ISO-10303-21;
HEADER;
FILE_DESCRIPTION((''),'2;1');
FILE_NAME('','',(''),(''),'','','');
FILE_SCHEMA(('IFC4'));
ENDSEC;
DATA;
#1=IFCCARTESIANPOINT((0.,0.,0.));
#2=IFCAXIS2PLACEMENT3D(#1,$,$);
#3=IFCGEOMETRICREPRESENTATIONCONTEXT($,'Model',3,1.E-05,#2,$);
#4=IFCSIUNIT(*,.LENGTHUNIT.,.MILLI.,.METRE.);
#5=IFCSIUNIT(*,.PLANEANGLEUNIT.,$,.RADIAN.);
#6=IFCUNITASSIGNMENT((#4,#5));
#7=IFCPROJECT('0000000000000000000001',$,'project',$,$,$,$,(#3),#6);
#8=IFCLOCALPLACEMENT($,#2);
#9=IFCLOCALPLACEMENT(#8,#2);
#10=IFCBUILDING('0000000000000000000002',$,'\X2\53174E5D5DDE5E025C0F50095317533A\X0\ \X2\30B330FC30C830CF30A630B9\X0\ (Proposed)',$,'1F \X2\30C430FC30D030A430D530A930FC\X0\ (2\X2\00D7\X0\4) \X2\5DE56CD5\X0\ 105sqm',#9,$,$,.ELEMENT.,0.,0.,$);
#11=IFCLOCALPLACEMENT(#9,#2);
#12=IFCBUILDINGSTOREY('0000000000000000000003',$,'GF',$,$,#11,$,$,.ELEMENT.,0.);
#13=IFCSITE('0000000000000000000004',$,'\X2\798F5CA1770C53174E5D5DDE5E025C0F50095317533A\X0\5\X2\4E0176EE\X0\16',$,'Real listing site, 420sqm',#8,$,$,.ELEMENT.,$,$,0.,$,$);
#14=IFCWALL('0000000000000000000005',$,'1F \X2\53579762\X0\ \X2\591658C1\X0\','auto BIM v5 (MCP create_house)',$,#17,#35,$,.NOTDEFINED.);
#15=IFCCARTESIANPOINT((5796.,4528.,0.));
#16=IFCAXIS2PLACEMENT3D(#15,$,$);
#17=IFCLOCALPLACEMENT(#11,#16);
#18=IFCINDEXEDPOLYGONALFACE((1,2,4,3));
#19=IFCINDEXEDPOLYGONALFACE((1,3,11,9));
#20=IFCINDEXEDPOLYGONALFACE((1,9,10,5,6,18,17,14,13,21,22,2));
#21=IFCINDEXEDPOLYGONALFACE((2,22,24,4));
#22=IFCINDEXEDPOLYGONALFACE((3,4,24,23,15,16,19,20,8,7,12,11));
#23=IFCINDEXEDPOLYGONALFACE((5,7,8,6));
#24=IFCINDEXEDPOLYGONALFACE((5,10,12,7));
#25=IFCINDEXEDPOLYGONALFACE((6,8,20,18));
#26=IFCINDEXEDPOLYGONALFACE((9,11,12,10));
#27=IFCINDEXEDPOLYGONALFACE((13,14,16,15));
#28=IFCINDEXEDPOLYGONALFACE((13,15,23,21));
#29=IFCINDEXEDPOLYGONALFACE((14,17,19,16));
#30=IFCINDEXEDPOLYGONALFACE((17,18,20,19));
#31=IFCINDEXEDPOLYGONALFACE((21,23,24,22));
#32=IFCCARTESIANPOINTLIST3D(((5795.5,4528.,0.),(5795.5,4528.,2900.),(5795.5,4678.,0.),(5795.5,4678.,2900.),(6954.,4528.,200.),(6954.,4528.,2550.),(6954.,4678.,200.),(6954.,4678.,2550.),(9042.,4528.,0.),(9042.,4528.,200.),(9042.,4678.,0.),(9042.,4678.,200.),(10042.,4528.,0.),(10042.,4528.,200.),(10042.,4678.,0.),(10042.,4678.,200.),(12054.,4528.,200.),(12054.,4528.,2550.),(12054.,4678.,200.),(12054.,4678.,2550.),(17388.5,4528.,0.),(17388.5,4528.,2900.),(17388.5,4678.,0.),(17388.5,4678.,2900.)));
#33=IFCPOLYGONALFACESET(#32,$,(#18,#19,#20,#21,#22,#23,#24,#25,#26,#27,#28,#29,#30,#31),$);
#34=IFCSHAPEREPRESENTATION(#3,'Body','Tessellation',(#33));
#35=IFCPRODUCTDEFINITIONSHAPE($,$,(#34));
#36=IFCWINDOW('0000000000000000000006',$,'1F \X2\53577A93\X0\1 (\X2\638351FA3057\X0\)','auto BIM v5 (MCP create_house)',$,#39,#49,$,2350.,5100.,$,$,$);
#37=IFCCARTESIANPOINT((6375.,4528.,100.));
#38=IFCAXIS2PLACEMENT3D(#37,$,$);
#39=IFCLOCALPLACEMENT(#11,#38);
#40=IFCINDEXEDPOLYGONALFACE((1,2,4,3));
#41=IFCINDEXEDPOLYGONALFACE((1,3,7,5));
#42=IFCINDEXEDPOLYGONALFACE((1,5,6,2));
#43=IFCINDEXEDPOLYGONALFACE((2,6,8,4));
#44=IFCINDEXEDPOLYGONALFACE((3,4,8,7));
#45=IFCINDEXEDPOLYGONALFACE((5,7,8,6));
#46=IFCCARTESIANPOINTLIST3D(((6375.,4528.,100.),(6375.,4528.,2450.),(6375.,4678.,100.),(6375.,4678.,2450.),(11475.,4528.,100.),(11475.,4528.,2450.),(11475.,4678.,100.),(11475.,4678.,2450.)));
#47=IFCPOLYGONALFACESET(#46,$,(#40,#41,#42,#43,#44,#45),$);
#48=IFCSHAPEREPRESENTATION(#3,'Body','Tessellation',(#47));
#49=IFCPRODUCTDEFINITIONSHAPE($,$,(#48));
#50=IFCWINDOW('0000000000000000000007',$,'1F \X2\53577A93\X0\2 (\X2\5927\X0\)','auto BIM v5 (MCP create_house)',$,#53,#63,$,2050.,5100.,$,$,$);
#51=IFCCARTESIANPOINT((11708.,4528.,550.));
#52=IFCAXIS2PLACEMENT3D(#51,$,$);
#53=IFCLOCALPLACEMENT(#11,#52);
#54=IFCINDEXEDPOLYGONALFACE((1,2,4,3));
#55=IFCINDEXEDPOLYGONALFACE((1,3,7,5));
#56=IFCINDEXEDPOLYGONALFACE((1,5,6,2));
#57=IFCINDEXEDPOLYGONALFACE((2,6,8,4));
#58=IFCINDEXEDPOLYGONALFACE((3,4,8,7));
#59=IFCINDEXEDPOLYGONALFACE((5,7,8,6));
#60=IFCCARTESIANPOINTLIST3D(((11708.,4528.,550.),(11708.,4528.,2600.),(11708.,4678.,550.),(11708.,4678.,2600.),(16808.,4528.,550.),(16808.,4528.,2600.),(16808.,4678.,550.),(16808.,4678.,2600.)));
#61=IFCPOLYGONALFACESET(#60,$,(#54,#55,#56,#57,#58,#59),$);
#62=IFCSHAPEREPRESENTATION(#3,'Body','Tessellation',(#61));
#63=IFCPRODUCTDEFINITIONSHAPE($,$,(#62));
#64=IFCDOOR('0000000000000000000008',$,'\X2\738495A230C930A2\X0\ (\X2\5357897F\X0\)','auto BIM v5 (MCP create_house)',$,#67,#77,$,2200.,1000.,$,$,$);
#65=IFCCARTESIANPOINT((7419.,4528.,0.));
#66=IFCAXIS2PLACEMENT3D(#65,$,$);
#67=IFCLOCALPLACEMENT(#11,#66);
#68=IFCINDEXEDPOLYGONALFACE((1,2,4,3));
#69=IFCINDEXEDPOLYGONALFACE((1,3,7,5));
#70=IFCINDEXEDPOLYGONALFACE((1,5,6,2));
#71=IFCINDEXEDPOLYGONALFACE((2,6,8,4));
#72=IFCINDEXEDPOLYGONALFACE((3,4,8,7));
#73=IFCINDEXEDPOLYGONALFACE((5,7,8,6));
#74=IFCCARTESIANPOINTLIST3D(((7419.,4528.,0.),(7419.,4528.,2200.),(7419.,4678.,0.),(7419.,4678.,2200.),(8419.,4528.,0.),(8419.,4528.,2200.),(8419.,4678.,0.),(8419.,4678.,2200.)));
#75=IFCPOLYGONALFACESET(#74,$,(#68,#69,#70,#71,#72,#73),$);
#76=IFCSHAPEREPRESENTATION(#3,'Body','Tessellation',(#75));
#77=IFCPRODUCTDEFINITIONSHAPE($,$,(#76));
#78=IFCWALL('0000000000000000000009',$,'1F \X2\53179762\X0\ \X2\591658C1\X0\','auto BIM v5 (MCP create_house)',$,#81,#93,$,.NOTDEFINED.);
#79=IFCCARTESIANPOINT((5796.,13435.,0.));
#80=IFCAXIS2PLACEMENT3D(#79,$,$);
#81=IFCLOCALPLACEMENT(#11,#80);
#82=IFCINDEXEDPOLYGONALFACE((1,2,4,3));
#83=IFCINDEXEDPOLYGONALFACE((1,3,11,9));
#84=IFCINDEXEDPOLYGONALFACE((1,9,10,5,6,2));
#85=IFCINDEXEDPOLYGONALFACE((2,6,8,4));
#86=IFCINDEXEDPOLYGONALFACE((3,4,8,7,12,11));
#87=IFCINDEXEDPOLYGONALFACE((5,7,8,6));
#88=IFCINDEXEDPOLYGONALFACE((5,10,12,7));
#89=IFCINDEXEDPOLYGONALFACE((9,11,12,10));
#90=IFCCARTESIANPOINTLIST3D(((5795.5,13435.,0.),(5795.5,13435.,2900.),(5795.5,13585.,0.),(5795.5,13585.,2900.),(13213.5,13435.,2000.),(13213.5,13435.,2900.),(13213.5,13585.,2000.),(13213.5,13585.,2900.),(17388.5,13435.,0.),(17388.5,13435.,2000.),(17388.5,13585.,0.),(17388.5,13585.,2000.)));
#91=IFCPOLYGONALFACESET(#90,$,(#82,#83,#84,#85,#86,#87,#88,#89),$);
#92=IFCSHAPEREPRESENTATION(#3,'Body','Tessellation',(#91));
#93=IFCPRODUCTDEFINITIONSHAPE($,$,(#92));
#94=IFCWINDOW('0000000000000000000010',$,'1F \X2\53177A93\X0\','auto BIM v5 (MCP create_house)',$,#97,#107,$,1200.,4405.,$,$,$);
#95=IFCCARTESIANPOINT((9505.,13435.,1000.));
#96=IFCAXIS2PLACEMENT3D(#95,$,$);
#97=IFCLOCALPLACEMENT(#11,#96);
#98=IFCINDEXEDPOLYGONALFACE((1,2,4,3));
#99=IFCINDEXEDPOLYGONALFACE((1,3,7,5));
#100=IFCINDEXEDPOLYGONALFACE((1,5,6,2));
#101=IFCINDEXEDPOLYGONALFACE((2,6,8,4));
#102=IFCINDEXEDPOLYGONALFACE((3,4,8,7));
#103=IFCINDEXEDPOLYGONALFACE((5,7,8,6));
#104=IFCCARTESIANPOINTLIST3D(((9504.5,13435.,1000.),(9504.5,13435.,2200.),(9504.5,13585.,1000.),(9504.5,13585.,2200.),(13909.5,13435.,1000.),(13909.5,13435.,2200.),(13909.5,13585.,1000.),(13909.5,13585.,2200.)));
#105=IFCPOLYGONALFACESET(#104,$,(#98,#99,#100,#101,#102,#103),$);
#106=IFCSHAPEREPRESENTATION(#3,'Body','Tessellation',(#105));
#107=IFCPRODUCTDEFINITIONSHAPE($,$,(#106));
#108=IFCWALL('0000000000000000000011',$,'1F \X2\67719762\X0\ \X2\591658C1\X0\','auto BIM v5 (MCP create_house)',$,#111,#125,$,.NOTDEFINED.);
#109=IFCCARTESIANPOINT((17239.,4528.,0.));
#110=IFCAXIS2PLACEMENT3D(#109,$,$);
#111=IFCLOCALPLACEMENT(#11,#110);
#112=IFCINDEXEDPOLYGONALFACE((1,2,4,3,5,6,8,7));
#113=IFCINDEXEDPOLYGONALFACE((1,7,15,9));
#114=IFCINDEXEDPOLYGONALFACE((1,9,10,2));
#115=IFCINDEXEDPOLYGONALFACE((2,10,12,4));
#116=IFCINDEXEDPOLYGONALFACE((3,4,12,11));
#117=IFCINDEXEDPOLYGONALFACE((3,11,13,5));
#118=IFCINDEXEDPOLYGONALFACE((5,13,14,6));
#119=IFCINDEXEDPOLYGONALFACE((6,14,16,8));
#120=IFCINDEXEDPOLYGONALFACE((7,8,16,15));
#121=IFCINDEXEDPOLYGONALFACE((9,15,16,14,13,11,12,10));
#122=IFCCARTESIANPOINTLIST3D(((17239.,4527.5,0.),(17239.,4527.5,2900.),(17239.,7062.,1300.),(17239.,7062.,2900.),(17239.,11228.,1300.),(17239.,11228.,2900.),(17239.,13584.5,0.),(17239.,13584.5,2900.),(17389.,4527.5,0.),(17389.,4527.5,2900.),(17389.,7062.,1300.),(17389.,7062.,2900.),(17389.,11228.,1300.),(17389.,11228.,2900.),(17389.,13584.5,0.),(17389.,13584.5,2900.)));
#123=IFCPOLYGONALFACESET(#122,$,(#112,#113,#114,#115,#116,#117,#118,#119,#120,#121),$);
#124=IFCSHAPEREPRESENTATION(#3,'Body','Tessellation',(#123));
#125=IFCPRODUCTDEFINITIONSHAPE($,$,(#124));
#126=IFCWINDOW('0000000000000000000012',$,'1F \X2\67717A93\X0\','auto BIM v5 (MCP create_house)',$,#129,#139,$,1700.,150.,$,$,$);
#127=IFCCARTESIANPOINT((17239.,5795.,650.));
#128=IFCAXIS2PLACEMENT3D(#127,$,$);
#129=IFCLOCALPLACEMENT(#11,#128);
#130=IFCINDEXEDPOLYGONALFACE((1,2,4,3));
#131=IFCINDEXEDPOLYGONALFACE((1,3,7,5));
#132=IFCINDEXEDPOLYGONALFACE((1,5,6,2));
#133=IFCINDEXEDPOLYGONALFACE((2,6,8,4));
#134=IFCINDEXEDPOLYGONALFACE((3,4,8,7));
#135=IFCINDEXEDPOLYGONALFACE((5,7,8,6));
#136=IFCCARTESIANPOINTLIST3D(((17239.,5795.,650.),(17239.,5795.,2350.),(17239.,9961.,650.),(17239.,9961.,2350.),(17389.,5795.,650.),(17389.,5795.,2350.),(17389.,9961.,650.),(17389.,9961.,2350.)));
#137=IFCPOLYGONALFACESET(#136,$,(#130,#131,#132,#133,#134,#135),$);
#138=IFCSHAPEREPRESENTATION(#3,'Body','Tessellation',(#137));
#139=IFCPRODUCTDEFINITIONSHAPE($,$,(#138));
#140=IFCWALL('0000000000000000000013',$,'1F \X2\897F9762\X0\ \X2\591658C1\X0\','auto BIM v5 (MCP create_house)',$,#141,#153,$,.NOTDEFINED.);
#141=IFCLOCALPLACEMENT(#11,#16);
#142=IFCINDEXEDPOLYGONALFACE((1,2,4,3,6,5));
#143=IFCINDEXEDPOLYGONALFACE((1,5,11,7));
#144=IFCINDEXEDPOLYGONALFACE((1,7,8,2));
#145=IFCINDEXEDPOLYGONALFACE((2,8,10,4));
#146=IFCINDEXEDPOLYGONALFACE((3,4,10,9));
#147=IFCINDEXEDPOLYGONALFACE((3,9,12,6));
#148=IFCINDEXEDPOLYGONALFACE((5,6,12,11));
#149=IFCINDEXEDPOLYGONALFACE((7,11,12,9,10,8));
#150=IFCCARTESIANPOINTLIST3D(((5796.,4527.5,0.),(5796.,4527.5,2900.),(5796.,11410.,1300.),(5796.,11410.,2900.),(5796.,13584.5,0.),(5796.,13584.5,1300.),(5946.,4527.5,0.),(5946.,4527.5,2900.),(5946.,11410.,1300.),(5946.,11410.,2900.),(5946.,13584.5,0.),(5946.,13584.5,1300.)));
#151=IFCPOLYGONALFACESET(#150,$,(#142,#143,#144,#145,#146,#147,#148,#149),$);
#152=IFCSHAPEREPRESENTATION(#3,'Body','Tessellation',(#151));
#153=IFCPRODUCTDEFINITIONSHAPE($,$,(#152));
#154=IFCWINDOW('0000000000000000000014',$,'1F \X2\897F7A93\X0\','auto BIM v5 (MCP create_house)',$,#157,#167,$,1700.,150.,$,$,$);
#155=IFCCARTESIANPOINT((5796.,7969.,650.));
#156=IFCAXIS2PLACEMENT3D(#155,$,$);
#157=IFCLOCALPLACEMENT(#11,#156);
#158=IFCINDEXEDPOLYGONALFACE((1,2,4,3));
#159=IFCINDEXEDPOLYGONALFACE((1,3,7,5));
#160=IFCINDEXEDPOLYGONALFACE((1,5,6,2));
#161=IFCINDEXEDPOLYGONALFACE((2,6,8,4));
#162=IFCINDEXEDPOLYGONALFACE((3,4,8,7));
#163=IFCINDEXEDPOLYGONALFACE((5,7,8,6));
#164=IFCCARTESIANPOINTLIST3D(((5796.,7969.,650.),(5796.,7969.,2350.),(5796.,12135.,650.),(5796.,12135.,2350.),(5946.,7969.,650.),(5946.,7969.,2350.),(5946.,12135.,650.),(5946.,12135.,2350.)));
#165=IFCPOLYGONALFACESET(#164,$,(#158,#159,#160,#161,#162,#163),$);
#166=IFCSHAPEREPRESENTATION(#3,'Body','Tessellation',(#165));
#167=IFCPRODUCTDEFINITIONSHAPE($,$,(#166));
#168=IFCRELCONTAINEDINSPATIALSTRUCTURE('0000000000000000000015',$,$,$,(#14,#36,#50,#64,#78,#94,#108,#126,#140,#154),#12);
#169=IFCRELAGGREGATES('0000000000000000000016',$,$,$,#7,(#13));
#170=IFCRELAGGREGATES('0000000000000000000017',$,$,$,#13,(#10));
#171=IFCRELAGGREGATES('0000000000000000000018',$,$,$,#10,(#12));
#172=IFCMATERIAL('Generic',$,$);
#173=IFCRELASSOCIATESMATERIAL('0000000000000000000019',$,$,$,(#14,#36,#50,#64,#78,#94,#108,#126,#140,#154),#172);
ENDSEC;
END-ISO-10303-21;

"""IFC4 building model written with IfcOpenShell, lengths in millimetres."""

from ifc_helpers import new_model, si_unit, frame, frame_2d, origin, place, context, project, spatial, rectangle, extrude, material, element, fill, save


model = new_model("IFC4")

# Units and contexts
model_context = context("Model", 3, precision=1e-05, world=origin())
ifc_project = project(units=[si_unit("LENGTHUNIT", "METRE", prefix="MILLI"), si_unit("PLANEANGLEUNIT", "RADIAN")], contexts=[model_context])

# Site, building, storey
site_placement = place(None, origin())
site = spatial("IfcSite", under=ifc_project, at=site_placement, Name="福岡県北九州市小倉北区5丁目16", ObjectType="Real listing site, 420sqm", CompositionType="ELEMENT", RefElevation=0.0)
building_placement = place(site_placement, origin())
building = spatial("IfcBuilding", under=site, at=building_placement, Name="北九州市小倉北区 コートハウス (Proposed)", ObjectType="1F ツーバイフォー (2×4) 工法 105sqm", CompositionType="ELEMENT", ElevationOfRefHeight=0.0, ElevationOfTerrain=0.0)
storey_placement = place(building_placement, origin())
storey = spatial("IfcBuildingStorey", under=building, at=storey_placement, Name="GF", CompositionType="ELEMENT", Elevation=0.0)

# Shared definitions
ifc_material = material(Name="Generic")

# Wall, openings, windows, door
wall_1_placement = place(storey_placement, frame((5796.0, 4528.0, 0.0)))
wall_1 = element("IfcWall", 1, at=wall_1_placement, inside=storey, material=ifc_material, Name="1F 南面 外壁", Description="auto BIM v5 (MCP create_house)", PredefinedType="NOTDEFINED", context=model_context, shape_type="SweptSolid", body=[
    extrude(rectangle(XDim=11593.0, YDim=150.0, at=frame_2d((5796.0, 75.0))), frame((5796.0, 4528.0, 0.0)), (0.0, 0.0, 1.0), 2900.0),
])
opening_1_placement = place(storey_placement, frame((6375.0, 4528.0, 100.0)))
opening_1 = element("IfcOpeningElement", 2, at=opening_1_placement, cuts=wall_1, PredefinedType="NOTDEFINED", context=model_context, shape_type="SweptSolid", body=[
    extrude(rectangle(XDim=5100.0, YDim=150.0, at=frame_2d((2550.0, 75.0))), frame((6375.0, 4528.0, 100.0)), (0.0, 0.0, 1.0), 2350.0),
])
opening_2_placement = place(storey_placement, frame((11708.0, 4528.0, 550.0)))
opening_2 = element("IfcOpeningElement", 3, at=opening_2_placement, cuts=wall_1, PredefinedType="NOTDEFINED", context=model_context, shape_type="SweptSolid", body=[
    extrude(rectangle(XDim=5100.0, YDim=150.0, at=frame_2d((2550.0, 75.0))), frame((11708.0, 4528.0, 550.0)), (0.0, 0.0, 1.0), 2050.0),
])
opening_3_placement = place(storey_placement, frame((7419.0, 4528.0, 0.0)))
opening_3 = element("IfcOpeningElement", 4, at=opening_3_placement, cuts=wall_1, PredefinedType="NOTDEFINED", context=model_context, shape_type="SweptSolid", body=[
    extrude(rectangle(XDim=1000.0, YDim=150.0, at=frame_2d((500.0, 75.0))), frame((7419.0, 4528.0, 0.0)), (0.0, 0.0, 1.0), 2200.0),
])
window_1_placement = place(storey_placement, frame((6375.0, 4528.0, 100.0)))
window_1 = element("IfcWindow", 5, at=window_1_placement, inside=storey, material=ifc_material, Name="1F 南窓1 (掃出し)", Description="auto BIM v5 (MCP create_house)", OverallHeight=2350.0, OverallWidth=5100.0, context=model_context, shape_type="SweptSolid", body=[
    extrude(rectangle(XDim=5100.0, YDim=150.0, at=frame_2d((2550.0, 75.0))), frame((6375.0, 4528.0, 100.0)), (0.0, 0.0, 1.0), 2350.0),
])
fill(opening_1, window_1)
window_2_placement = place(storey_placement, frame((11708.0, 4528.0, 550.0)))
window_2 = element("IfcWindow", 6, at=window_2_placement, inside=storey, material=ifc_material, Name="1F 南窓2 (大)", Description="auto BIM v5 (MCP create_house)", OverallHeight=2050.0, OverallWidth=5100.0, context=model_context, shape_type="SweptSolid", body=[
    extrude(rectangle(XDim=5100.0, YDim=150.0, at=frame_2d((2550.0, 75.0))), frame((11708.0, 4528.0, 550.0)), (0.0, 0.0, 1.0), 2050.0),
])
fill(opening_2, window_2)
door_placement = place(storey_placement, frame((7419.0, 4528.0, 0.0)))
door = element("IfcDoor", 7, at=door_placement, inside=storey, material=ifc_material, Name="玄関ドア (南西)", Description="auto BIM v5 (MCP create_house)", OverallHeight=2200.0, OverallWidth=1000.0, context=model_context, shape_type="SweptSolid", body=[
    extrude(rectangle(XDim=1000.0, YDim=150.0, at=frame_2d((500.0, 75.0))), frame((7419.0, 4528.0, 0.0)), (0.0, 0.0, 1.0), 2200.0),
])
fill(opening_3, door)

# Walls, openings, windows
wall_2_placement = place(storey_placement, frame((5796.0, 13435.0, 0.0)))
wall_2 = element("IfcWall", 8, at=wall_2_placement, inside=storey, material=ifc_material, Name="1F 北面 外壁", Description="auto BIM v5 (MCP create_house)", PredefinedType="NOTDEFINED", context=model_context, shape_type="SweptSolid", body=[
    extrude(rectangle(XDim=11593.0, YDim=150.0, at=frame_2d((5796.0, 75.0))), frame((5796.0, 13435.0, 0.0)), (0.0, 0.0, 1.0), 2900.0),
])
opening_4_placement = place(storey_placement, frame((9505.0, 13435.0, 1000.0)))
opening_4 = element("IfcOpeningElement", 9, at=opening_4_placement, cuts=wall_2, PredefinedType="NOTDEFINED", context=model_context, shape_type="SweptSolid", body=[
    extrude(rectangle(XDim=4405.0, YDim=150.0, at=frame_2d((2202.0, 75.0))), frame((9505.0, 13435.0, 1000.0)), (0.0, 0.0, 1.0), 1200.0),
])
window_3_placement = place(storey_placement, frame((9505.0, 13435.0, 1000.0)))
window_3 = element("IfcWindow", 10, at=window_3_placement, inside=storey, material=ifc_material, Name="1F 北窓", Description="auto BIM v5 (MCP create_house)", OverallHeight=1200.0, OverallWidth=4405.0, context=model_context, shape_type="SweptSolid", body=[
    extrude(rectangle(XDim=4405.0, YDim=150.0, at=frame_2d((2202.0, 75.0))), frame((9505.0, 13435.0, 1000.0)), (0.0, 0.0, 1.0), 1200.0),
])
fill(opening_4, window_3)
wall_3_placement = place(storey_placement, frame((17239.0, 4528.0, 0.0)))
wall_3 = element("IfcWall", 11, at=wall_3_placement, inside=storey, material=ifc_material, Name="1F 東面 外壁", Description="auto BIM v5 (MCP create_house)", PredefinedType="NOTDEFINED", context=model_context, shape_type="SweptSolid", body=[
    extrude(rectangle(XDim=150.0, YDim=9057.0, at=frame_2d((75.0, 4528.0))), frame((17239.0, 4528.0, 0.0)), (0.0, 0.0, 1.0), 2900.0),
])
opening_5_placement = place(storey_placement, frame((17239.0, 5795.0, 650.0)))
opening_5 = element("IfcOpeningElement", 12, at=opening_5_placement, cuts=wall_3, PredefinedType="NOTDEFINED", context=model_context, shape_type="SweptSolid", body=[
    extrude(rectangle(XDim=150.0, YDim=4166.0, at=frame_2d((75.0, 2083.0))), frame((17239.0, 5795.0, 650.0)), (0.0, 0.0, 1.0), 1700.0),
])
window_4_placement = place(storey_placement, frame((17239.0, 5795.0, 650.0)))
window_4 = element("IfcWindow", 13, at=window_4_placement, inside=storey, material=ifc_material, Name="1F 東窓", Description="auto BIM v5 (MCP create_house)", OverallHeight=1700.0, OverallWidth=150.0, context=model_context, shape_type="SweptSolid", body=[
    extrude(rectangle(XDim=150.0, YDim=4166.0, at=frame_2d((75.0, 2083.0))), frame((17239.0, 5795.0, 650.0)), (0.0, 0.0, 1.0), 1700.0),
])
fill(opening_5, window_4)
wall_4_placement = place(storey_placement, frame((5796.0, 4528.0, 0.0)))
wall_4 = element("IfcWall", 14, at=wall_4_placement, inside=storey, material=ifc_material, Name="1F 西面 外壁", Description="auto BIM v5 (MCP create_house)", PredefinedType="NOTDEFINED", context=model_context, shape_type="SweptSolid", body=[
    extrude(rectangle(XDim=150.0, YDim=9057.0, at=frame_2d((75.0, 4528.0))), frame((5796.0, 4528.0, 0.0)), (0.0, 0.0, 1.0), 2900.0),
])
opening_6_placement = place(storey_placement, frame((5796.0, 7969.0, 650.0)))
opening_6 = element("IfcOpeningElement", 15, at=opening_6_placement, cuts=wall_4, PredefinedType="NOTDEFINED", context=model_context, shape_type="SweptSolid", body=[
    extrude(rectangle(XDim=150.0, YDim=4166.0, at=frame_2d((75.0, 2083.0))), frame((5796.0, 7969.0, 650.0)), (0.0, 0.0, 1.0), 1700.0),
])
window_5_placement = place(storey_placement, frame((5796.0, 7969.0, 650.0)))
window_5 = element("IfcWindow", 16, at=window_5_placement, inside=storey, material=ifc_material, Name="1F 西窓", Description="auto BIM v5 (MCP create_house)", OverallHeight=1700.0, OverallWidth=150.0, context=model_context, shape_type="SweptSolid", body=[
    extrude(rectangle(XDim=150.0, YDim=4166.0, at=frame_2d((75.0, 2083.0))), frame((5796.0, 7969.0, 650.0)), (0.0, 0.0, 1.0), 1700.0),
])
fill(opening_6, window_5)

save(model, "model.ifc")
